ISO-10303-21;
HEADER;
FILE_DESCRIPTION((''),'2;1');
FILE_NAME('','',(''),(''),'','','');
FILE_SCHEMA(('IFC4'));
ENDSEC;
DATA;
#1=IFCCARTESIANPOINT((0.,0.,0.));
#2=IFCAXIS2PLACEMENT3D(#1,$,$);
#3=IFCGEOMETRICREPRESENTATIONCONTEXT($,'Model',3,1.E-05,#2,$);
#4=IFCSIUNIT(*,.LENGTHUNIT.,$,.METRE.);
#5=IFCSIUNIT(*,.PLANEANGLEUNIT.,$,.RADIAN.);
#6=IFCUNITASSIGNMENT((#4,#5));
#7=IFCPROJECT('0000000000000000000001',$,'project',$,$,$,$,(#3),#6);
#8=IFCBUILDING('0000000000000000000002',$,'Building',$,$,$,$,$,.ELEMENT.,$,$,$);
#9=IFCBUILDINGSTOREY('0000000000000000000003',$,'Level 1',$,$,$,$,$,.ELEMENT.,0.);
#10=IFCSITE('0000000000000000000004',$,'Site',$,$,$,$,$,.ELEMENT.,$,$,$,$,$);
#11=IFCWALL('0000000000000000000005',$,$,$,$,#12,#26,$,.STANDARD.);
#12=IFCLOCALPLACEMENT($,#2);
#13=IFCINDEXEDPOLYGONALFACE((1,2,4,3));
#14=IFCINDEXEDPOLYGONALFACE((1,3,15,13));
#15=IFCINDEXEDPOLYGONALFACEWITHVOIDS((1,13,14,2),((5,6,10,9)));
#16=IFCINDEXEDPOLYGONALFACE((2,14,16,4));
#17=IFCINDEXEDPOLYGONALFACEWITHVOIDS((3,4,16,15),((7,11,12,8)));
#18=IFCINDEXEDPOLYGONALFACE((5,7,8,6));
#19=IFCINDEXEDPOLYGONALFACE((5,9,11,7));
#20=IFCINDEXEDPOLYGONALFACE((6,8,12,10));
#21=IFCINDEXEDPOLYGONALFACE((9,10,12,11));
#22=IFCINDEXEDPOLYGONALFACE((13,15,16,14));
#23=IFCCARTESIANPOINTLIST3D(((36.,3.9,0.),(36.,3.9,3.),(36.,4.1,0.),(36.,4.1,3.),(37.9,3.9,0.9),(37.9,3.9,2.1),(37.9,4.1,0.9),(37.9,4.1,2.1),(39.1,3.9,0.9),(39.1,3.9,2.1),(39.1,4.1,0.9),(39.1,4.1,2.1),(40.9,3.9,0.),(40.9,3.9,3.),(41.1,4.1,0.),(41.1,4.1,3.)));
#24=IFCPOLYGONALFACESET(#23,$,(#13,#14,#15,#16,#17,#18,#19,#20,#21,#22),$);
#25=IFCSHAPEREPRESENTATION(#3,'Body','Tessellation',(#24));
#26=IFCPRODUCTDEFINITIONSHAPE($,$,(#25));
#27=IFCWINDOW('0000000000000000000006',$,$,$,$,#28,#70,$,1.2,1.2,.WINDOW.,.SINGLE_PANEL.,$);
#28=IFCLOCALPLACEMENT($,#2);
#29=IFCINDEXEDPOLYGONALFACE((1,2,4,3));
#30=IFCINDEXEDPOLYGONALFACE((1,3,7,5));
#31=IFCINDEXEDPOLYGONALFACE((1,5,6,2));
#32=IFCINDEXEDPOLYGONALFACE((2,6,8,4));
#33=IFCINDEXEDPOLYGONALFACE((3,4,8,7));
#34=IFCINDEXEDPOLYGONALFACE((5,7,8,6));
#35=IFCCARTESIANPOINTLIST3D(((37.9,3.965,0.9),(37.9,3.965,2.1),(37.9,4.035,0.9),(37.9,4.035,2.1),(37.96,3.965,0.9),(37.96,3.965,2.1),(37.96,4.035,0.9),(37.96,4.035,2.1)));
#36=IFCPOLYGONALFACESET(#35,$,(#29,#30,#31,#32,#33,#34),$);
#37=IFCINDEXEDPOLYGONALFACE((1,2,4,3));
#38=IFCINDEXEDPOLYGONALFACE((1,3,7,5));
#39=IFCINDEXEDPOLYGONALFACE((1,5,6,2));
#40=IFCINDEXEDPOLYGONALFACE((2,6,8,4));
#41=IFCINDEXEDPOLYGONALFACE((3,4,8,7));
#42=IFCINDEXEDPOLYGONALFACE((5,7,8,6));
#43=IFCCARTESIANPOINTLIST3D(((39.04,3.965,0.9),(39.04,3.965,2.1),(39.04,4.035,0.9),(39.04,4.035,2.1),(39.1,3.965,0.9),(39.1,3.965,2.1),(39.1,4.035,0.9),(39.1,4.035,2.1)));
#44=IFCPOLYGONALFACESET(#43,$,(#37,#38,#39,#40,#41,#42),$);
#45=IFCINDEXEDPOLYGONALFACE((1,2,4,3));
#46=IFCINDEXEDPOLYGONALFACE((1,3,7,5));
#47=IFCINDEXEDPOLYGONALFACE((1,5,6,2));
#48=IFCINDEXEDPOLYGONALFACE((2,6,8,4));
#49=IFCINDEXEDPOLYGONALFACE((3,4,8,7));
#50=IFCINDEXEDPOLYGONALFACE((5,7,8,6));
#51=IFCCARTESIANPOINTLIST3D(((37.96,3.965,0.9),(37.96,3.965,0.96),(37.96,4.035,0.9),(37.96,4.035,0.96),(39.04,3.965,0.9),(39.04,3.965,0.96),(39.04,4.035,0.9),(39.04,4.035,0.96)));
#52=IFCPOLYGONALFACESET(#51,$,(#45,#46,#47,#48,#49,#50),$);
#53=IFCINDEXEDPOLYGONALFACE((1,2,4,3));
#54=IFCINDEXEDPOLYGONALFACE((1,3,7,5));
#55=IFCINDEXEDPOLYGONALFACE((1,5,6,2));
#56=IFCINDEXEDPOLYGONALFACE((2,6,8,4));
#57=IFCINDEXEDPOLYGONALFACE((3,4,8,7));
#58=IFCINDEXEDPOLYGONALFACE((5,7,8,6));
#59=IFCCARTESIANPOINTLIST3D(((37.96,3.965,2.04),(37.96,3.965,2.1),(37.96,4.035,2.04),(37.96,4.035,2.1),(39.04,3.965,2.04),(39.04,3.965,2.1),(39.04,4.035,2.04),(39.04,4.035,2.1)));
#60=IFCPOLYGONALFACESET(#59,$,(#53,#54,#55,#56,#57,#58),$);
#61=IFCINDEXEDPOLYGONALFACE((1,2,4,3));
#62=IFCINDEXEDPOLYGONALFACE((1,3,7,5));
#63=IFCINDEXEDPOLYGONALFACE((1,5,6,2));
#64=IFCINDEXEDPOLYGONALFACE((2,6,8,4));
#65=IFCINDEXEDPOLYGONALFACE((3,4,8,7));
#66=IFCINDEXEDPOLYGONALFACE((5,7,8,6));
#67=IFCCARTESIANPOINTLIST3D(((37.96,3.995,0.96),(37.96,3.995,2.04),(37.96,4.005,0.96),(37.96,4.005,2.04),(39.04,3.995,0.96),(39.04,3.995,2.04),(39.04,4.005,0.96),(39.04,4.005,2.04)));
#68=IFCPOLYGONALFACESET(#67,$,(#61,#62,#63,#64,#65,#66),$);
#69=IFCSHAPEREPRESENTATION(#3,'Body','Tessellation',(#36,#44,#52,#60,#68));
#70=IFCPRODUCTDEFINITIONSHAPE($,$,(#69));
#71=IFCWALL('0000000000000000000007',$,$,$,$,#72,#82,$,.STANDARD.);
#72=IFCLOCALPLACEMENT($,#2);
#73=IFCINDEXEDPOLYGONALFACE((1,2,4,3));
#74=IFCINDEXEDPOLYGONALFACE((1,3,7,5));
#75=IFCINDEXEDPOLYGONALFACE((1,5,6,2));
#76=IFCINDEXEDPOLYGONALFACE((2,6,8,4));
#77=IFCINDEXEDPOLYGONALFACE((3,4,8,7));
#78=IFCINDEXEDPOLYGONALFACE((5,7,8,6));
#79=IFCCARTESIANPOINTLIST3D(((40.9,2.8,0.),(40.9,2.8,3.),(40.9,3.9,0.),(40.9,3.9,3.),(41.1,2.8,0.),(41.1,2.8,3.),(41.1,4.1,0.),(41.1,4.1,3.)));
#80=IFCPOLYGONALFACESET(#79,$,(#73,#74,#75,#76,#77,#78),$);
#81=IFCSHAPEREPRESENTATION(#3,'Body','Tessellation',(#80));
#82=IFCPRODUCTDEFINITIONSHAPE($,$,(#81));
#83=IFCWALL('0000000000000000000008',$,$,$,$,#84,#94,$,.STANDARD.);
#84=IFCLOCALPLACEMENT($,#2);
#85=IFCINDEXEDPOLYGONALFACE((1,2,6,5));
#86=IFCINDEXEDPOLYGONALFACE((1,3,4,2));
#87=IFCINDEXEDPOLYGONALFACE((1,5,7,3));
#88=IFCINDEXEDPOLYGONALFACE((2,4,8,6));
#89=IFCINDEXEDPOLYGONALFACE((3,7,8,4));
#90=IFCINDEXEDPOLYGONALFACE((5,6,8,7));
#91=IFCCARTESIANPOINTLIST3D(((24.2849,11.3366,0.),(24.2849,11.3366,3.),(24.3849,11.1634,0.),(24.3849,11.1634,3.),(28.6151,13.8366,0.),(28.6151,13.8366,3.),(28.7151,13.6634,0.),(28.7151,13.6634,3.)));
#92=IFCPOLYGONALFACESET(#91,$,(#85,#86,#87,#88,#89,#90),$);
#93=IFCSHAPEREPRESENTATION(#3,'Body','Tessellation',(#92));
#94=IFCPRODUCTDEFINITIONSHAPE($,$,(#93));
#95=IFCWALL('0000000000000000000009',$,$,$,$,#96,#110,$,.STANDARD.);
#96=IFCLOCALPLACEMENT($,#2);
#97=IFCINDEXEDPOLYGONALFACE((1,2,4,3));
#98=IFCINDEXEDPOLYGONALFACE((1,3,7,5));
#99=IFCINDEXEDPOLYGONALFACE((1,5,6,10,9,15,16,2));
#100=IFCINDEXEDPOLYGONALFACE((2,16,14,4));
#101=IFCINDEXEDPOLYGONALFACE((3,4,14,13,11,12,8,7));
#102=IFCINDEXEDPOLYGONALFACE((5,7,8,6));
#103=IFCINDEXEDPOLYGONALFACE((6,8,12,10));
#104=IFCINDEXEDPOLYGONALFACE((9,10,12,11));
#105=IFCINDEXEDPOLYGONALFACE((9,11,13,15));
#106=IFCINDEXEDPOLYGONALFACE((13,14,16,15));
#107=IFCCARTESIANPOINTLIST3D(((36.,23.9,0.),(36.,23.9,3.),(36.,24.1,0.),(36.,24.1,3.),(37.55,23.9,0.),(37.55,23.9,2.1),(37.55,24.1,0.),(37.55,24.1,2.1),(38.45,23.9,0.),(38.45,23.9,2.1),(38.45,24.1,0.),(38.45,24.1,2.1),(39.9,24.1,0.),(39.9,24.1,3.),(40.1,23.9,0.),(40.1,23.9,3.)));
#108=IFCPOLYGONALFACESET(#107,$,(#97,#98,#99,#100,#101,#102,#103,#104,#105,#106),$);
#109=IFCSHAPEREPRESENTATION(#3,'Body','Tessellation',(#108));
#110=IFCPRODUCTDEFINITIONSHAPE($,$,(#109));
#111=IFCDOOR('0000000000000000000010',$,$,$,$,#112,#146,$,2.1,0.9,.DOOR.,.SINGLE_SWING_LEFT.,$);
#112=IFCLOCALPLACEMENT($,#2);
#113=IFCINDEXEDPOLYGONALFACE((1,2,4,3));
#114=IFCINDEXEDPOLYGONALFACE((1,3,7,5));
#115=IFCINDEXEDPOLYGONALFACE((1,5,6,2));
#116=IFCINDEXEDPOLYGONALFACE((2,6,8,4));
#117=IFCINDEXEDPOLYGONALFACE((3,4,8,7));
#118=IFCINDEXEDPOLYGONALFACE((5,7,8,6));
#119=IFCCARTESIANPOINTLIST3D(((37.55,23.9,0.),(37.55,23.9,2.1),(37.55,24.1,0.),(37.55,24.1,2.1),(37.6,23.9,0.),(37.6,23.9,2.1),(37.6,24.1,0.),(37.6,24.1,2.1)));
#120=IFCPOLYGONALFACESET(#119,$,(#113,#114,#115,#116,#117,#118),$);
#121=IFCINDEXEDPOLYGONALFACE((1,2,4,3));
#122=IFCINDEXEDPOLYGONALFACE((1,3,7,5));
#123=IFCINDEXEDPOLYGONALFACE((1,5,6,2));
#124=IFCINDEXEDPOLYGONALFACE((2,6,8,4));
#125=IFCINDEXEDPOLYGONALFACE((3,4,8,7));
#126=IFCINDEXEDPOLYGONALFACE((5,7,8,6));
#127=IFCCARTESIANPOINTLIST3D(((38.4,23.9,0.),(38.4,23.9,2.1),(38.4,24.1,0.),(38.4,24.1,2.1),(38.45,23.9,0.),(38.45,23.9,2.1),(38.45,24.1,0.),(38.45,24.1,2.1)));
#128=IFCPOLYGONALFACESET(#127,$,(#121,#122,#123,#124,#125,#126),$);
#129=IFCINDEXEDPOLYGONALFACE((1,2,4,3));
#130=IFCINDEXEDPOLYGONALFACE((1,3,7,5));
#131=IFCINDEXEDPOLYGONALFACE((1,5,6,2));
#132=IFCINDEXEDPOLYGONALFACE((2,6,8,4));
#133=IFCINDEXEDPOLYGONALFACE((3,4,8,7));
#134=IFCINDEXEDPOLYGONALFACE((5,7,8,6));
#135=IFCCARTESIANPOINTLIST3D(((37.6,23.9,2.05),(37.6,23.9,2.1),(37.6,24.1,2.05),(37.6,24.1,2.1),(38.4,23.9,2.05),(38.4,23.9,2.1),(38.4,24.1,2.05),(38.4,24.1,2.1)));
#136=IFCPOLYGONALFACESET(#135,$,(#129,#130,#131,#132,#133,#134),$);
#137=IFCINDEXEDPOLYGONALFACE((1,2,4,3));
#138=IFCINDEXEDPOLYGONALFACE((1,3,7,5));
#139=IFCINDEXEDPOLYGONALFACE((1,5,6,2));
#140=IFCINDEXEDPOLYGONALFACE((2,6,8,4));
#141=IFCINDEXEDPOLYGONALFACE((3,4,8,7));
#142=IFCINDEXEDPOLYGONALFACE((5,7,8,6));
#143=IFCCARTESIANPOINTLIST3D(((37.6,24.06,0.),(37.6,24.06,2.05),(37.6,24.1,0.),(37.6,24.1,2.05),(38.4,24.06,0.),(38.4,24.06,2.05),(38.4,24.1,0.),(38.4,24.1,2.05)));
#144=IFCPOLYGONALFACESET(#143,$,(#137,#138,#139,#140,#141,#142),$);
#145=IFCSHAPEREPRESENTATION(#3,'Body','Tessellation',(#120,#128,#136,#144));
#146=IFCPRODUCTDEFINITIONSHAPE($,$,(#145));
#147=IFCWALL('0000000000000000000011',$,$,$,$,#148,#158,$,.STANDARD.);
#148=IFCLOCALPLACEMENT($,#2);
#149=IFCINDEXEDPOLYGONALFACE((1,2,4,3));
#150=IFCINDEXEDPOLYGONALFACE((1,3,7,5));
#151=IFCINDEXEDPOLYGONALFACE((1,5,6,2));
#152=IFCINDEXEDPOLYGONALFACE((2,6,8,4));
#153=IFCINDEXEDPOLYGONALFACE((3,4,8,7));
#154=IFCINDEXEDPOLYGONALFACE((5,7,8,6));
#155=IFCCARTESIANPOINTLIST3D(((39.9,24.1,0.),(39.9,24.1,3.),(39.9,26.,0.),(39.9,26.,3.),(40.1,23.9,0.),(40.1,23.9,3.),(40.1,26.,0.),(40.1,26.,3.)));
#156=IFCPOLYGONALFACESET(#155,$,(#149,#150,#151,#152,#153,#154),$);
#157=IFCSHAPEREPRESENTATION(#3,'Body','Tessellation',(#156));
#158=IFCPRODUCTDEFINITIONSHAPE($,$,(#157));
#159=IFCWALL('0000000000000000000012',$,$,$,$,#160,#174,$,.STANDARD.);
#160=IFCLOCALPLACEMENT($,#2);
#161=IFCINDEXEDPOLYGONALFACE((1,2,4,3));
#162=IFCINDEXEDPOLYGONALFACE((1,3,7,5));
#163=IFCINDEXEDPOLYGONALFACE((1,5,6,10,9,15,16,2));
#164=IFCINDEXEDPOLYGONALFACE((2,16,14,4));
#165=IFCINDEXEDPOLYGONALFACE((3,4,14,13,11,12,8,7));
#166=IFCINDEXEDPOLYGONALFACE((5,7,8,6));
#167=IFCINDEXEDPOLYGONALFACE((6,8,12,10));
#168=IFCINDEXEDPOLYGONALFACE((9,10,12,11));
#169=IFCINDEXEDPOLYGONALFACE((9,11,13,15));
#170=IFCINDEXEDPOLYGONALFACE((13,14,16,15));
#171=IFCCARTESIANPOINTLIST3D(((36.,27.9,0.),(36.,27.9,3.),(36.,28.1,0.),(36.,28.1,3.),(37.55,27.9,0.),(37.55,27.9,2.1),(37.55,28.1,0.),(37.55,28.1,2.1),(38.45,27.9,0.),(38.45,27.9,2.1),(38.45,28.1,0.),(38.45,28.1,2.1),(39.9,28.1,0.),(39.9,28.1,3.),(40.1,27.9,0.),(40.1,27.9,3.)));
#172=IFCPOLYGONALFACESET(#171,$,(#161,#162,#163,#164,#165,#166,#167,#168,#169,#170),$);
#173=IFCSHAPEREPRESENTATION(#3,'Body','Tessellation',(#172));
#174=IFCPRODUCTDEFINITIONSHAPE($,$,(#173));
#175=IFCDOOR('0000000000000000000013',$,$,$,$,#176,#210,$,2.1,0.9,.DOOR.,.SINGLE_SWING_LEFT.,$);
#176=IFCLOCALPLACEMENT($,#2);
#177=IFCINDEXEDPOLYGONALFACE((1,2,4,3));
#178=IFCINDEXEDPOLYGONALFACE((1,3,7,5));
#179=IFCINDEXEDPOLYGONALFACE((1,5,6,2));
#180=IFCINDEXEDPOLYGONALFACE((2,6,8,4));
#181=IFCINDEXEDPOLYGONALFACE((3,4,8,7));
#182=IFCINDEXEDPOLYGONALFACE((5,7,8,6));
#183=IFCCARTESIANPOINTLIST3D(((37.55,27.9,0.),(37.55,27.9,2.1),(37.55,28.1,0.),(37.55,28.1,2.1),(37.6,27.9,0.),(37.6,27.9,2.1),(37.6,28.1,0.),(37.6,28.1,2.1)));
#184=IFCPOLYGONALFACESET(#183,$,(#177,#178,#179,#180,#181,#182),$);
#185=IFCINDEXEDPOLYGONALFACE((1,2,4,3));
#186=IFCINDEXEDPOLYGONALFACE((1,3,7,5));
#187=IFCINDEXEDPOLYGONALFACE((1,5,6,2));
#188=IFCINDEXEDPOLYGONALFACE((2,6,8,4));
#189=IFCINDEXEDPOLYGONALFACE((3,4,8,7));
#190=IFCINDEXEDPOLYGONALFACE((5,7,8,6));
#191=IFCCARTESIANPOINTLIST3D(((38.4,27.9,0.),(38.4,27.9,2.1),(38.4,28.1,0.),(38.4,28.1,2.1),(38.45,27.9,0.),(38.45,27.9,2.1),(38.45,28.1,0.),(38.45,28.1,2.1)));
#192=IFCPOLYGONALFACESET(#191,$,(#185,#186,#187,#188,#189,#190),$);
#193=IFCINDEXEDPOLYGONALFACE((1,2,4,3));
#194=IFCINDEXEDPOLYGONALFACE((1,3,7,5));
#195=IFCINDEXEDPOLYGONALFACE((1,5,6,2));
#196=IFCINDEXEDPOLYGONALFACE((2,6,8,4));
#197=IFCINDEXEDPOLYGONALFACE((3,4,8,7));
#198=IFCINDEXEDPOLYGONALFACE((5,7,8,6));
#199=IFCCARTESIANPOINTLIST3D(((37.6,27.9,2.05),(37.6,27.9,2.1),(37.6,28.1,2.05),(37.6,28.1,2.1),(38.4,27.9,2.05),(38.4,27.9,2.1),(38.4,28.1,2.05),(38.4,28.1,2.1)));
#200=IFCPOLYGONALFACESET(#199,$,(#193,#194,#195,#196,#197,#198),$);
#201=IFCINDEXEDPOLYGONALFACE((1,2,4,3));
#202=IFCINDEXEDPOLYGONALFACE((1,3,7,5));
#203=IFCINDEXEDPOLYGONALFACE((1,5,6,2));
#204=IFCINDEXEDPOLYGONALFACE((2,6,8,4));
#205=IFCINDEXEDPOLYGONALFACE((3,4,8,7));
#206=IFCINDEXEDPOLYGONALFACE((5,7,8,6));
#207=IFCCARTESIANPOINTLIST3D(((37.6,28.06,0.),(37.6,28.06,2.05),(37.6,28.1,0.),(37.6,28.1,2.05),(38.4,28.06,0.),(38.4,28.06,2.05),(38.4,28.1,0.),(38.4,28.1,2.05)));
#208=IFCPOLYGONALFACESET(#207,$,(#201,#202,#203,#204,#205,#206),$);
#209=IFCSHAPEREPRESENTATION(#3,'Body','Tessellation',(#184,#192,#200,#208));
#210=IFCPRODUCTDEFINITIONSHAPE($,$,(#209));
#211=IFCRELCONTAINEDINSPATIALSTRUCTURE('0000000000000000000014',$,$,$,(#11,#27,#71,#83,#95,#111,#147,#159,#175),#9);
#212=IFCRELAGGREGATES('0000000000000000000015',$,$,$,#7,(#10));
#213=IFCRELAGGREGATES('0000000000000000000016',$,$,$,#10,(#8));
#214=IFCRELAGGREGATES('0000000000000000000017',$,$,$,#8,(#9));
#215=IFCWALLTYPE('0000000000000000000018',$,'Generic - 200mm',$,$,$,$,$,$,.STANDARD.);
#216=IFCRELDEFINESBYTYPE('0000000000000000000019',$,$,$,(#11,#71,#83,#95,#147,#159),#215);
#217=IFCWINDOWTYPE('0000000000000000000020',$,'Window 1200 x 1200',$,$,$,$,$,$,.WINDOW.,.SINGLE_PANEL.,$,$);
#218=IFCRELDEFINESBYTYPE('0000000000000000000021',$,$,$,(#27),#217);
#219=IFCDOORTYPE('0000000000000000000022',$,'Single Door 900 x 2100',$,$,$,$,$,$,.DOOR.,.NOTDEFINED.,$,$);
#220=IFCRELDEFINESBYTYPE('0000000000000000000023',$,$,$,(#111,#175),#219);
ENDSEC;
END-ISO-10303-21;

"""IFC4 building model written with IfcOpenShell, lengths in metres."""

from ifc_helpers import new_model, si_unit, frame, frame_2d, origin, origin_with_axes, origin_2d, place, context, project, spatial, polyline, rectangle, outline, extrude, type_object, element, fill, save


model = new_model("IFC4")

# Units and contexts
model_context = context("Model", 3, precision=1e-05, world=origin())
ifc_project = project(units=[si_unit("LENGTHUNIT", "METRE"), si_unit("PLANEANGLEUNIT", "RADIAN")], contexts=[model_context])

# Site, building, storey
site = spatial("IfcSite", under=ifc_project, Name="Site", CompositionType="ELEMENT")
building = spatial("IfcBuilding", under=site, Name="Building", CompositionType="ELEMENT")
storey = spatial("IfcBuildingStorey", under=building, Name="Level 1", CompositionType="ELEMENT", Elevation=0.0)

# Shared definitions
wall_type = type_object("IfcWallType", Name="Generic - 200mm", PredefinedType="STANDARD")
door_type = type_object("IfcDoorType", Name="Single Door 900 x 2100", OperationType="NOTDEFINED", PredefinedType="DOOR")

# Shared definitions
window_type = type_object("IfcWindowType", Name="Window 1200 x 1200", PartitioningType="SINGLE_PANEL", PredefinedType="WINDOW")

# Wall, opening, window
wall_1_placement = place(None, frame((36.0, 4.0, 0.0), z_axis=(0.0, 0.0, 1.0), x_axis=(1.0, 0.0, 0.0)))
wall_1 = element("IfcWall", 1, at=wall_1_placement, inside=storey, type_object=wall_type, PredefinedType="STANDARD", context=model_context, shape_type="SweptSolid", body=[
    extrude(outline(polyline([(0.0, -0.1), (4.9, -0.1), (5.1, 0.1), (0.0, 0.1), (0.0, -0.1)])), origin(), (0.0, 0.0, 1.0), 3.0),
])
opening_1_placement = place(wall_1_placement, frame((2.5, 0.0, 0.9), z_axis=(0.0, 0.0, 1.0), x_axis=(1.0, 0.0, 0.0)))
opening_1 = element("IfcOpeningElement", 2, at=opening_1_placement, cuts=wall_1, PredefinedType="OPENING", context=model_context, shape_type="SweptSolid", body=[
    extrude(rectangle(XDim=1.2, YDim=0.202, at=origin_2d()), origin(), (0.0, 0.0, 1.0), 1.2),
])
window_1_placement = place(opening_1_placement, origin_with_axes())
window_1 = element("IfcWindow", 3, at=window_1_placement, inside=storey, type_object=window_type, OverallHeight=1.2, OverallWidth=1.2, PartitioningType="SINGLE_PANEL", PredefinedType="WINDOW", context=model_context, shape_type="SweptSolid", body=[
    extrude(rectangle(XDim=0.06, YDim=0.07, at=frame_2d((-0.57, 0.0))), origin(), (0.0, 0.0, 1.0), 1.2),
    extrude(rectangle(XDim=0.06, YDim=0.07, at=frame_2d((0.57, 0.0))), origin(), (0.0, 0.0, 1.0), 1.2),
    extrude(rectangle(XDim=1.08, YDim=0.07, at=origin_2d()), origin(), (0.0, 0.0, 1.0), 0.06),
    extrude(rectangle(XDim=1.08, YDim=0.07, at=origin_2d()), frame((0.0, 0.0, 1.14)), (0.0, 0.0, 1.0), 0.06),
    extrude(rectangle(XDim=1.08, YDim=0.01, at=origin_2d()), frame((0.0, 0.0, 0.06)), (0.0, 0.0, 1.0), 1.08),
])
fill(opening_1, window_1)

# Walls
wall_2_placement = place(None, frame((41.0, 4.0, 0.0), z_axis=(0.0, 0.0, 1.0), x_axis=(0.0, -1.0, 0.0)))
element("IfcWall", 4, at=wall_2_placement, inside=storey, type_object=wall_type, PredefinedType="STANDARD", context=model_context, shape_type="SweptSolid", body=[
    extrude(outline(polyline([(0.1, -0.1), (1.2, -0.1), (1.2, 0.1), (-0.1, 0.1), (0.1, -0.1)])), origin(), (0.0, 0.0, 1.0), 3.0),
])
wall_3_placement = place(None, frame((24.3349, 11.25, 0.0), z_axis=(0.0, 0.0, 1.0), x_axis=(0.866025, 0.5, 0.0)))
element("IfcWall", 5, at=wall_3_placement, inside=storey, type_object=wall_type, PredefinedType="STANDARD", context=model_context, shape_type="SweptSolid", body=[
    extrude(rectangle(XDim=5.0, YDim=0.2, at=frame_2d((2.5, 0.0))), origin(), (0.0, 0.0, 1.0), 3.0),
])

# Wall, opening, door
wall_4_placement = place(None, frame((36.0, 24.0, 0.0), z_axis=(0.0, 0.0, 1.0), x_axis=(1.0, 0.0, 0.0)))
wall_4 = element("IfcWall", 6, at=wall_4_placement, inside=storey, type_object=wall_type, PredefinedType="STANDARD", context=model_context, shape_type="SweptSolid", body=[
    extrude(outline(polyline([(0.0, -0.1), (4.1, -0.1), (3.9, 0.1), (0.0, 0.1), (0.0, -0.1)])), origin(), (0.0, 0.0, 1.0), 3.0),
])
opening_2_placement = place(wall_4_placement, frame((2.0, 0.0, 0.0), z_axis=(0.0, 0.0, 1.0), x_axis=(1.0, 0.0, 0.0)))
opening_2 = element("IfcOpeningElement", 7, at=opening_2_placement, cuts=wall_4, PredefinedType="OPENING", context=model_context, shape_type="SweptSolid", body=[
    extrude(rectangle(XDim=0.9, YDim=0.202, at=origin_2d()), origin(), (0.0, 0.0, 1.0), 2.1),
])
door_1_placement = place(opening_2_placement, origin_with_axes())
door_1 = element("IfcDoor", 8, at=door_1_placement, inside=storey, type_object=door_type, OperationType="SINGLE_SWING_LEFT", OverallHeight=2.1, OverallWidth=0.9, PredefinedType="DOOR", context=model_context, shape_type="SweptSolid", body=[
    extrude(rectangle(XDim=0.05, YDim=0.2, at=frame_2d((-0.425, 0.0))), origin(), (0.0, 0.0, 1.0), 2.1),
    extrude(rectangle(XDim=0.05, YDim=0.2, at=frame_2d((0.425, 0.0))), origin(), (0.0, 0.0, 1.0), 2.1),
    extrude(rectangle(XDim=0.8, YDim=0.2, at=origin_2d()), frame((0.0, 0.0, 2.05)), (0.0, 0.0, 1.0), 0.05),
    extrude(rectangle(XDim=0.8, YDim=0.04, at=frame_2d((0.0, 0.08))), origin(), (0.0, 0.0, 1.0), 2.05),
])
fill(opening_2, door_1)

# Wall
wall_5_placement = place(None, frame((40.0, 24.0, 0.0), z_axis=(0.0, 0.0, 1.0), x_axis=(0.0, 1.0, 0.0)))
element("IfcWall", 9, at=wall_5_placement, inside=storey, type_object=wall_type, PredefinedType="STANDARD", context=model_context, shape_type="SweptSolid", body=[
    extrude(outline(polyline([(-0.1, -0.1), (2.0, -0.1), (2.0, 0.1), (0.1, 0.1), (-0.1, -0.1)])), origin(), (0.0, 0.0, 1.0), 3.0),
])

# Wall, opening, door
wall_6_placement = place(None, frame((36.0, 28.0, 0.0), z_axis=(0.0, 0.0, 1.0), x_axis=(1.0, 0.0, 0.0)))
wall_6 = element("IfcWall", 10, at=wall_6_placement, inside=storey, type_object=wall_type, PredefinedType="STANDARD", context=model_context, shape_type="SweptSolid", body=[
    extrude(outline(polyline([(0.0, -0.1), (4.1, -0.1), (3.9, 0.1), (0.0, 0.1), (0.0, -0.1)])), origin(), (0.0, 0.0, 1.0), 3.0),
])
opening_3_placement = place(wall_6_placement, frame((2.0, 0.0, 0.0), z_axis=(0.0, 0.0, 1.0), x_axis=(1.0, 0.0, 0.0)))
opening_3 = element("IfcOpeningElement", 11, at=opening_3_placement, cuts=wall_6, PredefinedType="OPENING", context=model_context, shape_type="SweptSolid", body=[
    extrude(rectangle(XDim=0.9, YDim=0.202, at=origin_2d()), origin(), (0.0, 0.0, 1.0), 2.1),
])
door_2_placement = place(opening_3_placement, origin_with_axes())
door_2 = element("IfcDoor", 12, at=door_2_placement, inside=storey, type_object=door_type, OperationType="SINGLE_SWING_LEFT", OverallHeight=2.1, OverallWidth=0.9, PredefinedType="DOOR", context=model_context, shape_type="SweptSolid", body=[
    extrude(rectangle(XDim=0.05, YDim=0.2, at=frame_2d((-0.425, 0.0))), origin(), (0.0, 0.0, 1.0), 2.1),
    extrude(rectangle(XDim=0.05, YDim=0.2, at=frame_2d((0.425, 0.0))), origin(), (0.0, 0.0, 1.0), 2.1),
    extrude(rectangle(XDim=0.8, YDim=0.2, at=origin_2d()), frame((0.0, 0.0, 2.05)), (0.0, 0.0, 1.0), 0.05),
    extrude(rectangle(XDim=0.8, YDim=0.04, at=frame_2d((0.0, 0.08))), origin(), (0.0, 0.0, 1.0), 2.05),
])
fill(opening_3, door_2)

save(model, "model.ifc")
